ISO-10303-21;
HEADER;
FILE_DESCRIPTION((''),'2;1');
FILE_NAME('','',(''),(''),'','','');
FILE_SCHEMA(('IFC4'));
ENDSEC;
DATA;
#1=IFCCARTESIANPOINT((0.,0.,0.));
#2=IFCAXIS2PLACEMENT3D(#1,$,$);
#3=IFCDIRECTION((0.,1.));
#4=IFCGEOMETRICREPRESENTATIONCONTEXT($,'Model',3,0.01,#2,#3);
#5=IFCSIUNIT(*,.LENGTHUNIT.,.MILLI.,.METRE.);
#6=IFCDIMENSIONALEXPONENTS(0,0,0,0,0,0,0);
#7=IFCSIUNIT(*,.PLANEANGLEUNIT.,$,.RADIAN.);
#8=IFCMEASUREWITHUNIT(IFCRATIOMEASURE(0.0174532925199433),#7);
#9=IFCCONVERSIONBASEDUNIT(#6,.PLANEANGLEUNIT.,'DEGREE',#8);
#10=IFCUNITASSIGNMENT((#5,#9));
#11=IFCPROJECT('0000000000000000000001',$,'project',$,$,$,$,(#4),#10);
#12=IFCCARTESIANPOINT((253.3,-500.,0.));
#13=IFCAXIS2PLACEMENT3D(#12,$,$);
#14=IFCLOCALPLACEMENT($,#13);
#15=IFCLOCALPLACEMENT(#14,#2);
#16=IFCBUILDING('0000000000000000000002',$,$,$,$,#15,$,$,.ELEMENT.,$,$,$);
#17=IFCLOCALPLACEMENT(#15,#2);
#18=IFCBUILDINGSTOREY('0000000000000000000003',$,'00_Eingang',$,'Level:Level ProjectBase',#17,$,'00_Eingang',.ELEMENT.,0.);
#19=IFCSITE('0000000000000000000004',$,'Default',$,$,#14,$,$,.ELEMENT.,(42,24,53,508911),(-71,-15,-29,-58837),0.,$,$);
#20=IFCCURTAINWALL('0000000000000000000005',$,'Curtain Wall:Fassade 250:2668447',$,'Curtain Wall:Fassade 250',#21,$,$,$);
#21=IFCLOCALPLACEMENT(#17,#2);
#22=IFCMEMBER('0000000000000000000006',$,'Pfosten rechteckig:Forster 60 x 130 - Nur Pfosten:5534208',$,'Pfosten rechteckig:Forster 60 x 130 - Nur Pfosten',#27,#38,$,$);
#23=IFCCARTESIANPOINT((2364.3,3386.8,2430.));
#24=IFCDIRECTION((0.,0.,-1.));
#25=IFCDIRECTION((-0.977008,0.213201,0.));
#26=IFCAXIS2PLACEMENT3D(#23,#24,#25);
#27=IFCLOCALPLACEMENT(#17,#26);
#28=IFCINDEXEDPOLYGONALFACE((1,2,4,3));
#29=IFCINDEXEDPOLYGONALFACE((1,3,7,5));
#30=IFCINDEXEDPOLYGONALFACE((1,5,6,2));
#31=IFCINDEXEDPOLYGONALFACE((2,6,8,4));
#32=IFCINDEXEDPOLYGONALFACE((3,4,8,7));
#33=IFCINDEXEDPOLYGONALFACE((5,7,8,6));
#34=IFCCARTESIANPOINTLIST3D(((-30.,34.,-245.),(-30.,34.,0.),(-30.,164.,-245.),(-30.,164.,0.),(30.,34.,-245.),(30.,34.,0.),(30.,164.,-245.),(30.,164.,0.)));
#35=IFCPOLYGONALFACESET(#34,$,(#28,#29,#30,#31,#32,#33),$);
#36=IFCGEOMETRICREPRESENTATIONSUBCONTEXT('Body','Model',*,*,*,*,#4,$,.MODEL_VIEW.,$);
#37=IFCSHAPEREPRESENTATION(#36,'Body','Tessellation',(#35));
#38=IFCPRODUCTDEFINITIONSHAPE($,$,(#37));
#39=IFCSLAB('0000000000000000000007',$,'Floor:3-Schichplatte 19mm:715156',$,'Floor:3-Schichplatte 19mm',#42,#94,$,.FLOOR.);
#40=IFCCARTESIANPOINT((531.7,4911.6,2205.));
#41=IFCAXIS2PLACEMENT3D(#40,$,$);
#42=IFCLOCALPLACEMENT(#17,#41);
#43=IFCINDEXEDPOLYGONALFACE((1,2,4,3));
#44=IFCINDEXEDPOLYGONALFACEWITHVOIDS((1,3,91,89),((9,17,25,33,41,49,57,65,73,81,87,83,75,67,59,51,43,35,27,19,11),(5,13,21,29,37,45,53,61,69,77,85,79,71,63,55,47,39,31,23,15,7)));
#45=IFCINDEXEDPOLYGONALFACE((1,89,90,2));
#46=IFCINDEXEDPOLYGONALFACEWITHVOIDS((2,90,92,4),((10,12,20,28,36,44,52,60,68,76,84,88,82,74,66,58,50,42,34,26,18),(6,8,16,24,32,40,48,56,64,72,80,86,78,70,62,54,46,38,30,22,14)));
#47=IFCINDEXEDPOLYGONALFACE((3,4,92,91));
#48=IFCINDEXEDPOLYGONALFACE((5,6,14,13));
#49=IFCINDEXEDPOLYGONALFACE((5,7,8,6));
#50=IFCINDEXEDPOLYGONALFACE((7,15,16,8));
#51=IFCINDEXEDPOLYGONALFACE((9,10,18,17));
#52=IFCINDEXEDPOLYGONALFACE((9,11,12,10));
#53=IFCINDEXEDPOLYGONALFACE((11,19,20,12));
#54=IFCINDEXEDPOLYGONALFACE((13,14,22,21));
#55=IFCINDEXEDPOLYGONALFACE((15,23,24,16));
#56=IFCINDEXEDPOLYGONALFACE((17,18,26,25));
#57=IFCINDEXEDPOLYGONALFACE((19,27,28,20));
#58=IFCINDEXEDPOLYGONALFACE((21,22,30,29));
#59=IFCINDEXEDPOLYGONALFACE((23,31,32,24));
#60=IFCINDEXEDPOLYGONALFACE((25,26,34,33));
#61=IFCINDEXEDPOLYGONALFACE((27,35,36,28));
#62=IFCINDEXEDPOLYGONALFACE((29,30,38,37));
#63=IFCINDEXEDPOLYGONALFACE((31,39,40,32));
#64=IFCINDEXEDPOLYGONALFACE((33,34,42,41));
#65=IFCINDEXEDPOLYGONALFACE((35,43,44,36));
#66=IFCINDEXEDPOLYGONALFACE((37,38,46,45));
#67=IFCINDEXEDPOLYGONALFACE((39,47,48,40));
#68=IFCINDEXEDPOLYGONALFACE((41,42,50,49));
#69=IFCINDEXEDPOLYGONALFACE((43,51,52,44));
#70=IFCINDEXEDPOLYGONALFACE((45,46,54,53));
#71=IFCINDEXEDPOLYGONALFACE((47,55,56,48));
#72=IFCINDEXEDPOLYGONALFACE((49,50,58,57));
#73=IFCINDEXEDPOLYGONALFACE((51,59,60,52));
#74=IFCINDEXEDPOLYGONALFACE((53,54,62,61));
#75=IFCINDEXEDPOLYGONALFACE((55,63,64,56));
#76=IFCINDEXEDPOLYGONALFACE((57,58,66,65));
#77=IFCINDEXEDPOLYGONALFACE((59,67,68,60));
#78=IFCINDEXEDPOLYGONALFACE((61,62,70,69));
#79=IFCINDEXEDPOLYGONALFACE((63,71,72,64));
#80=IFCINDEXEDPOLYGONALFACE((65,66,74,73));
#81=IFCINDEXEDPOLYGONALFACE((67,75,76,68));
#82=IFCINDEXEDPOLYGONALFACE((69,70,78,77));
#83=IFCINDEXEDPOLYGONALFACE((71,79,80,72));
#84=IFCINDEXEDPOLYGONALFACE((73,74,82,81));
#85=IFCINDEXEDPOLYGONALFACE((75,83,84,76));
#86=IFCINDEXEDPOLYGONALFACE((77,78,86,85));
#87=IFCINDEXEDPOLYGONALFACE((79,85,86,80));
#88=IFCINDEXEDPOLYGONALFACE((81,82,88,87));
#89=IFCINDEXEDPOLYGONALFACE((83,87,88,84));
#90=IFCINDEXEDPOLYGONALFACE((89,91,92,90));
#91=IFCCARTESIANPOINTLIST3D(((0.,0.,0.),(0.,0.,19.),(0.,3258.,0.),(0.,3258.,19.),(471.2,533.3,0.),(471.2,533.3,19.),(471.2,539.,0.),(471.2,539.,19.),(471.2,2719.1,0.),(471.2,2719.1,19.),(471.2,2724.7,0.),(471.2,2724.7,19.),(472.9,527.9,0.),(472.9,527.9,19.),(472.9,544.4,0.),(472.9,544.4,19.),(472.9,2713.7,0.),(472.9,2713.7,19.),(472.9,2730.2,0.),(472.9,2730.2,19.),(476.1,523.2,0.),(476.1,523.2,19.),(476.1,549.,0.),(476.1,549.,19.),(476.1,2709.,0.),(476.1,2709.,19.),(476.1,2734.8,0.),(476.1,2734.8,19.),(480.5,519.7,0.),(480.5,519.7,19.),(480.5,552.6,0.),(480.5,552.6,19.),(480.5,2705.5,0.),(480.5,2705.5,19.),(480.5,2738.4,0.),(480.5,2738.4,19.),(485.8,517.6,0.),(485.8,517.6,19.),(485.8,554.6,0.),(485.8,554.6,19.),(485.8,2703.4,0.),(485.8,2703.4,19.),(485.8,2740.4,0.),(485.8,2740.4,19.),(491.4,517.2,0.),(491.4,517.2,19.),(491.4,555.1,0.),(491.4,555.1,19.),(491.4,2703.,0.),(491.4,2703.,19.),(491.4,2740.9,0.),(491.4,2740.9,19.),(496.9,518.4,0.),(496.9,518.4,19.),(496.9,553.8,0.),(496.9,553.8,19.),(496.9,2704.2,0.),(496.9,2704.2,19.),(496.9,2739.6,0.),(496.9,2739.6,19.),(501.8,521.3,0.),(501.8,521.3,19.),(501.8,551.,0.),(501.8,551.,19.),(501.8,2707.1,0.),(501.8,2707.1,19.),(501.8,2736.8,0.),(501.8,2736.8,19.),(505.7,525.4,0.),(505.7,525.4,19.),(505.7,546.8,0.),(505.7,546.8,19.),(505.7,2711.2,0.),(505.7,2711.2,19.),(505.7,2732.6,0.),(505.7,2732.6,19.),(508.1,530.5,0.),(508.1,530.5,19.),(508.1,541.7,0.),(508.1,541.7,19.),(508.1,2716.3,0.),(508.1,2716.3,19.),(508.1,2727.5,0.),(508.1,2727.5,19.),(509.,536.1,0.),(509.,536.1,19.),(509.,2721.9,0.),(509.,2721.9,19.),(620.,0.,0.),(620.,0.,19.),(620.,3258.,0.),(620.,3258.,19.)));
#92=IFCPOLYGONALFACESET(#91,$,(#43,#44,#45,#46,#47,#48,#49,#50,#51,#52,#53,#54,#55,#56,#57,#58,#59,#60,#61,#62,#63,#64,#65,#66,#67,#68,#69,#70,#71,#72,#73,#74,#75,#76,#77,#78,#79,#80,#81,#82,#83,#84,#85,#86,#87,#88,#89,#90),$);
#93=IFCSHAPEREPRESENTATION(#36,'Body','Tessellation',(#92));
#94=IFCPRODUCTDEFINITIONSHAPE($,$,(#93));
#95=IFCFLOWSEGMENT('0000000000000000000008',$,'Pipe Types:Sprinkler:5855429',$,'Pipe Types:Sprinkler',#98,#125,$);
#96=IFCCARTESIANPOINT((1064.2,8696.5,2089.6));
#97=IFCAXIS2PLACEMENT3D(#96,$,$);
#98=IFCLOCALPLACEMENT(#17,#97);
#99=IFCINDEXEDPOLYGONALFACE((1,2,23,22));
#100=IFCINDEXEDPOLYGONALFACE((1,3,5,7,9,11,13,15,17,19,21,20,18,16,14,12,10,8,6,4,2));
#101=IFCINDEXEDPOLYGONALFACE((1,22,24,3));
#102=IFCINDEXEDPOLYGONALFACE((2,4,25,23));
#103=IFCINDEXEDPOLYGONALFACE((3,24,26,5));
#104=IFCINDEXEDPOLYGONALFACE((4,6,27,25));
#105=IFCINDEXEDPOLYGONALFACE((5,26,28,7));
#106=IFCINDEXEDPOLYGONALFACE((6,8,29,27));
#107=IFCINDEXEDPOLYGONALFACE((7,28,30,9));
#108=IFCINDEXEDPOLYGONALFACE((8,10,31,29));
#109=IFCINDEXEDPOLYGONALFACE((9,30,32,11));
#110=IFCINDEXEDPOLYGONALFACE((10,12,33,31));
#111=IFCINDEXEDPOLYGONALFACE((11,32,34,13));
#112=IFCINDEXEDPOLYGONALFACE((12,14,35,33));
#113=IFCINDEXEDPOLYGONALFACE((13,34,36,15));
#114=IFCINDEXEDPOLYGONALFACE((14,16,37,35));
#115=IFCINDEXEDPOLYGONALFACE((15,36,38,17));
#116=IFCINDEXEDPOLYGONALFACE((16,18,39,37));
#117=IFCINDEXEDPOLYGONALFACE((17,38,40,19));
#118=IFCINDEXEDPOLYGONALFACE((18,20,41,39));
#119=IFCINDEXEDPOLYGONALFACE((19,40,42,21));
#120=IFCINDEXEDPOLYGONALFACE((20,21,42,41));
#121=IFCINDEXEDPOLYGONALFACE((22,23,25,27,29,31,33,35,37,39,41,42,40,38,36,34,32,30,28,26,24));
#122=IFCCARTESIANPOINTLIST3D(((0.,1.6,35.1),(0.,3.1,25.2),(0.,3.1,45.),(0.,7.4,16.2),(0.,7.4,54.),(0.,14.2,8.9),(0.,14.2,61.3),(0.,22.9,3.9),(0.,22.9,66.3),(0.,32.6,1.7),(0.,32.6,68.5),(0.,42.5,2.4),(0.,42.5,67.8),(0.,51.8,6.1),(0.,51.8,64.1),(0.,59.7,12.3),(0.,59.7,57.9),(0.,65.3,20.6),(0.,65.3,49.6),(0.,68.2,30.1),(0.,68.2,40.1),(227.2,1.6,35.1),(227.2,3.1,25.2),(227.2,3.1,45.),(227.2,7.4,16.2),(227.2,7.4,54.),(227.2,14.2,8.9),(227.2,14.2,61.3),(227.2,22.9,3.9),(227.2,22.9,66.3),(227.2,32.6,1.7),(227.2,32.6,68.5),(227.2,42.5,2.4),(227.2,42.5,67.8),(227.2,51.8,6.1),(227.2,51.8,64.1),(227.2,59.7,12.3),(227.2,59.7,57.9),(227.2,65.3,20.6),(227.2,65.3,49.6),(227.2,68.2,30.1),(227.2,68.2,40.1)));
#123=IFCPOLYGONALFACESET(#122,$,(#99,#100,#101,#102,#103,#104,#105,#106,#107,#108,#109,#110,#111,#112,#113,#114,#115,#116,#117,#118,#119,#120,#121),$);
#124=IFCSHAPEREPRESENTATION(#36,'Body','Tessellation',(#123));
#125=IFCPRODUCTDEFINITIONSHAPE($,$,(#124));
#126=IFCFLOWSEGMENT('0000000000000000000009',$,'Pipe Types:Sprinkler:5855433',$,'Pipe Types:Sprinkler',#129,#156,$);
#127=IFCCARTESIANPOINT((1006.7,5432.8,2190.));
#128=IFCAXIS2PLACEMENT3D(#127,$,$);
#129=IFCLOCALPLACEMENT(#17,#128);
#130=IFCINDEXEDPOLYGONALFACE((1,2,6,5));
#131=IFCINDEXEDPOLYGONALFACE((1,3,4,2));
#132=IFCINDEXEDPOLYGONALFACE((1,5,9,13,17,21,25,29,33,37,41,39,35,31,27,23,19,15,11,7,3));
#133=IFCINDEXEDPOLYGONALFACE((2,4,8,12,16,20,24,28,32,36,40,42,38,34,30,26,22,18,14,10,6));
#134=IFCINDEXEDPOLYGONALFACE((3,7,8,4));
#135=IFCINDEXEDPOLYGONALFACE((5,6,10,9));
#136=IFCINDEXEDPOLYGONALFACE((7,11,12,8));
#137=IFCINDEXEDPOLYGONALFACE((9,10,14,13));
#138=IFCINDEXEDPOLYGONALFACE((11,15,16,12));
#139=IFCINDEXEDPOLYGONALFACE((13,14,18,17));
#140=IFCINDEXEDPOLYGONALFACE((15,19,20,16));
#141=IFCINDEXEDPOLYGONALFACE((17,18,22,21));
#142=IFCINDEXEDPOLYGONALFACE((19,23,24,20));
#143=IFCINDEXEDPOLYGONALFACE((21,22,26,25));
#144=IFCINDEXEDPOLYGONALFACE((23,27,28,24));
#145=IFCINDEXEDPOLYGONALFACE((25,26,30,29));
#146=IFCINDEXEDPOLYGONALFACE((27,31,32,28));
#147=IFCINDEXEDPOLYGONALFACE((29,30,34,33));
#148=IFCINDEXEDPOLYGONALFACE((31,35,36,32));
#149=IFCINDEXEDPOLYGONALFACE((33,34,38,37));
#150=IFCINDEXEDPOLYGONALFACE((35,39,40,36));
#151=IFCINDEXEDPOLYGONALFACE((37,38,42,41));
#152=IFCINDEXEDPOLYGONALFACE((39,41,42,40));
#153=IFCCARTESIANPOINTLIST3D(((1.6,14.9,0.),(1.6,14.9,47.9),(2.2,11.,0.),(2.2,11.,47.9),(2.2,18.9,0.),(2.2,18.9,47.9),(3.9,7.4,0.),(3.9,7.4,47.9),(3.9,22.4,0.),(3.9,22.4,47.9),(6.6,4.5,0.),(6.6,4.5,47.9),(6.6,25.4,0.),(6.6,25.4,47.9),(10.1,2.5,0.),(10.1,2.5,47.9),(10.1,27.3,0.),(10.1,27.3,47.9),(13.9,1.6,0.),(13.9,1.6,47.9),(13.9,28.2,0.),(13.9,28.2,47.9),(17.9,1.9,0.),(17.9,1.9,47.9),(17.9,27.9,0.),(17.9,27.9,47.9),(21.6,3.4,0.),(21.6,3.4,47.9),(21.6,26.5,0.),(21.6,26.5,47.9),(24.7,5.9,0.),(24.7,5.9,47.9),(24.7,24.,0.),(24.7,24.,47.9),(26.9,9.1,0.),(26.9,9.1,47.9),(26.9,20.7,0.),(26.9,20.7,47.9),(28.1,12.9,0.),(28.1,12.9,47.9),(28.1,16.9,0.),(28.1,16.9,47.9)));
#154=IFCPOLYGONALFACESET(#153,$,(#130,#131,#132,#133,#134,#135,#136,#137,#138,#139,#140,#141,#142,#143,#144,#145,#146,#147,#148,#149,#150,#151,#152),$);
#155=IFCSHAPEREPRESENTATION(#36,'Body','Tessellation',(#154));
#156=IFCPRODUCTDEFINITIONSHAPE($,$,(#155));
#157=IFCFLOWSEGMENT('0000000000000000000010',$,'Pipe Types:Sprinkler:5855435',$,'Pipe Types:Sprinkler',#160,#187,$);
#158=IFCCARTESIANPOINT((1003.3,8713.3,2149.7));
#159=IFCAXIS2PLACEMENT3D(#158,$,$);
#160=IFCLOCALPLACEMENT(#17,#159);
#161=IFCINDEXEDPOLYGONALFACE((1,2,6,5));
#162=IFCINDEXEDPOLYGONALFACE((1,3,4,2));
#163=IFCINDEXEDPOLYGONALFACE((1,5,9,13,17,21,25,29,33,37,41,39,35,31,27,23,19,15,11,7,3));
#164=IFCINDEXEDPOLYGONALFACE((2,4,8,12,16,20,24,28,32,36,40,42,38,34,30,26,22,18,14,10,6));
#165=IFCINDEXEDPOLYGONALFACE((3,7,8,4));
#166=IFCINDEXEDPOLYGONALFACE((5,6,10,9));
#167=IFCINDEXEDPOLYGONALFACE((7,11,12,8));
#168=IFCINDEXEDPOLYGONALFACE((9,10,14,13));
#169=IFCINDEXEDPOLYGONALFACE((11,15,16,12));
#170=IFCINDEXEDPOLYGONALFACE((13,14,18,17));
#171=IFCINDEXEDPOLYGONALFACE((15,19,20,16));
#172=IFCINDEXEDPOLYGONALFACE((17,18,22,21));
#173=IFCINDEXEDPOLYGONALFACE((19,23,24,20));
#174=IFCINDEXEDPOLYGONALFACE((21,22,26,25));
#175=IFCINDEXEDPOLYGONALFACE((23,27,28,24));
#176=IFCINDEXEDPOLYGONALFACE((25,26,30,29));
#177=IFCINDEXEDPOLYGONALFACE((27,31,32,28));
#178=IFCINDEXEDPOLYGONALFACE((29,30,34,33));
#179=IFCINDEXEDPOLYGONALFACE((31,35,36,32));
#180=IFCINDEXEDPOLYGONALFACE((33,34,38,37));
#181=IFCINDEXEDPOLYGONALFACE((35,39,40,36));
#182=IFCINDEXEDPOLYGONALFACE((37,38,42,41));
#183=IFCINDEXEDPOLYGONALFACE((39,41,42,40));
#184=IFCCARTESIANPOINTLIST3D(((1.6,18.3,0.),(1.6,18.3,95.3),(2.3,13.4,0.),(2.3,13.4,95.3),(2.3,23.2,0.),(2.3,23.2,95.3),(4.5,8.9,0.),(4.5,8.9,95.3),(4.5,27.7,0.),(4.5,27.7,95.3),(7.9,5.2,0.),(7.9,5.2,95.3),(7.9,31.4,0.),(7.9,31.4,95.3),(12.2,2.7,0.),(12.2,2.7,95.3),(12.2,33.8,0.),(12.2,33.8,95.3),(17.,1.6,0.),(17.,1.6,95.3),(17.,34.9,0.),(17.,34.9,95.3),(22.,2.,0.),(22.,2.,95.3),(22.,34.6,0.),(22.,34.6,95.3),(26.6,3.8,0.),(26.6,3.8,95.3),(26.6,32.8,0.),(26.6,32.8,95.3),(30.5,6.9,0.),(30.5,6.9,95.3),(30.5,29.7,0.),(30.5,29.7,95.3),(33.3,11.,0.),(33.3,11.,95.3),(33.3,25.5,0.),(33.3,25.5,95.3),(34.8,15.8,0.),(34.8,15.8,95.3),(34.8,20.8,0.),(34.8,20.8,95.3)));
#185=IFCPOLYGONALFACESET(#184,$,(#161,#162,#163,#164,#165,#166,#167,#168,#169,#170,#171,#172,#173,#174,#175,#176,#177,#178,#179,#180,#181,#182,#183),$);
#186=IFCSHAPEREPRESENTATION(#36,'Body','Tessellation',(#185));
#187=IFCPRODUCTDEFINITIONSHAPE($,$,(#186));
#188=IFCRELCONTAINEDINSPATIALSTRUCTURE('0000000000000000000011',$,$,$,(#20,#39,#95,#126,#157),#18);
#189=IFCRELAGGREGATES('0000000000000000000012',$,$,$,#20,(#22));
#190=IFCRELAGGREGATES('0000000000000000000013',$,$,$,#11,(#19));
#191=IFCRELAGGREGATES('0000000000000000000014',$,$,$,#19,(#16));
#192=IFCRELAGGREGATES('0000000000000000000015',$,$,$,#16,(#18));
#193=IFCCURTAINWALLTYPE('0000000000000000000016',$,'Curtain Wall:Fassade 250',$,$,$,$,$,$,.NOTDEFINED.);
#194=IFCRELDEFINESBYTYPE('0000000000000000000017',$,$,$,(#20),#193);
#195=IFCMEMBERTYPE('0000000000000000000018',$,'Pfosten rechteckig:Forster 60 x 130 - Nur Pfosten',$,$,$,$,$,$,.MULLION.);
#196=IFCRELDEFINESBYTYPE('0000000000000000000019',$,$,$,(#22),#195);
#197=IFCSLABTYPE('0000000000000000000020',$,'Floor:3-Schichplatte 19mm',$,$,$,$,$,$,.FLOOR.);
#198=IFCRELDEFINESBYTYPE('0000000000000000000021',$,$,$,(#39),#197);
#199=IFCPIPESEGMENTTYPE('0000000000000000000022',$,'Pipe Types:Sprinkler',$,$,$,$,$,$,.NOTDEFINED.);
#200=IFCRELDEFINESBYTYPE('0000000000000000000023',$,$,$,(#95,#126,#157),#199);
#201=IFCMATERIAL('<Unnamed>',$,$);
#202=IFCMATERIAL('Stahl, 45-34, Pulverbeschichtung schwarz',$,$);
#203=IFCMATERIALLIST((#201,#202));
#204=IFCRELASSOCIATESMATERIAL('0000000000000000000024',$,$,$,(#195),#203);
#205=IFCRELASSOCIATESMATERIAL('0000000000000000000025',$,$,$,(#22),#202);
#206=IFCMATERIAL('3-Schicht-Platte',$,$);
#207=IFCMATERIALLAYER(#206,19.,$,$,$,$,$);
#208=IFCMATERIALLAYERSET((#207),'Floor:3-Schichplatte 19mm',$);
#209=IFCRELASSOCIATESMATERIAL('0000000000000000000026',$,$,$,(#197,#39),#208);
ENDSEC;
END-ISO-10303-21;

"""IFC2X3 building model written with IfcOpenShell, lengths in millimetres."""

from ifc_helpers import new_model, entity, si_unit, converted_unit, direction, frame, frame_2d, origin, origin_2d_with_axis, place, context, subcontext, project, spatial, rectangle, circle, extrude, source, transform, mapped, material, material_list, layer, layer_set, layer_usage, type_object, type_shapes, element, aggregate, save


model = new_model("IFC2X3")

# Units and contexts
model_context = context("Model", 3, precision=0.01, world=origin(), true_north=direction((0.0, 1.0)))
body_context = subcontext(model_context, "Body", "Model", "MODEL_VIEW")
ifc_project = project(units=[si_unit("LENGTHUNIT", "METRE", prefix="MILLI"), converted_unit("PLANEANGLEUNIT", "DEGREE", entity("IfcRatioMeasure", 0.0174532925199433), si_unit("PLANEANGLEUNIT", "RADIAN"), dimensions=[0, 0, 0, 0, 0, 0, 0])], contexts=[model_context])

# Site, building, storey
site_placement = place(None, frame((253.3, -500.0, 0.0)))
site = spatial("IfcSite", under=ifc_project, at=site_placement, Name="Default", CompositionType="ELEMENT", RefLatitude=(42, 24, 53, 508911), RefLongitude=(-71, -15, -29, -58837), RefElevation=0.0)
building_placement = place(site_placement, origin())
building = spatial("IfcBuilding", under=site, at=building_placement, CompositionType="ELEMENT")
storey_placement = place(building_placement, origin())
storey = spatial("IfcBuildingStorey", under=building, at=storey_placement, Name="00_Eingang", ObjectType="Level:Level ProjectBase", LongName="00_Eingang", CompositionType="ELEMENT", Elevation=0.0)

# Curtain wall, member
curtain_wall_type = type_object("IfcCurtainWallType", Name="Curtain Wall:Fassade 250", PredefinedType="NOTDEFINED")
curtain_wall_placement = place(storey_placement, origin())
curtain_wall = element("IfcCurtainWall", 1, at=curtain_wall_placement, inside=storey, type_object=curtain_wall_type, Name="Curtain Wall:Fassade 250:2668447", ObjectType="Curtain Wall:Fassade 250")
ifc_material_1 = material(Name="Stahl, 45-34, Pulverbeschichtung schwarz")
ifc_material_2 = material(Name="<Unnamed>")
ifc_material_list = material_list([ifc_material_2, ifc_material_1])
member_type = type_object("IfcMemberType", Name="Pfosten rechteckig:Forster 60 x 130 - Nur Pfosten", PredefinedType="MULLION", material=ifc_material_list)
shared_shape_1 = source(origin(), body_context, "Body", "SweptSolid", [
    extrude(rectangle(XDim=130.0, YDim=60.0, at=origin_2d_with_axis()), frame((0.0, 99.0, -245.0), z_axis=(0.0, 0.0, 1.0), x_axis=(0.0, -1.0, 0.0)), (0.0, 0.0, 1.0), 245.0),
])
type_shapes(member_type, [shared_shape_1])
member_placement = place(storey_placement, frame((2364.3, 3386.8, 2430.0), z_axis=(0.0, 0.0, -1.0), x_axis=(-0.977008, 0.213201, 0.0)))
member = element("IfcMember", 2, at=member_placement, type_object=member_type, material=ifc_material_1, Name="Pfosten rechteckig:Forster 60 x 130 - Nur Pfosten:5534208", ObjectType="Pfosten rechteckig:Forster 60 x 130 - Nur Pfosten", context=body_context, shape_type="MappedRepresentation", body=[
    mapped(shared_shape_1, transform((0.0, 0.0, 0.0), scale=1.0)),
])

# Slab, openings
ifc_material_3 = material(Name="3-Schicht-Platte")
ifc_layer_1 = layer(ifc_material_3, 19.0)
ifc_layer_set_1 = layer_set([ifc_layer_1], Name="Floor:3-Schichplatte 19mm")
ifc_layer_usage_1 = layer_usage(ifc_layer_set_1, "AXIS3", "POSITIVE", 0.0)
slab_type = type_object("IfcSlabType", Name="Floor:3-Schichplatte 19mm", PredefinedType="FLOOR", material=ifc_layer_set_1)
slab_placement = place(storey_placement, frame((531.7, 4911.6, 2205.0)))
slab = element("IfcSlab", 3, at=slab_placement, inside=storey, type_object=slab_type, material=ifc_layer_usage_1, Name="Floor:3-Schichplatte 19mm:715156", ObjectType="Floor:3-Schichplatte 19mm", PredefinedType="FLOOR", context=body_context, shape_type="SweptSolid", body=[
    extrude(rectangle(XDim=620.0, YDim=3258.0, at=origin_2d_with_axis()), frame((310.0, 1629.0, 19.0), z_axis=(0.0, 0.0, -1.0), x_axis=(-1.0, 0.0, 0.0)), (0.0, 0.0, 1.0), 19.0),
])
opening_1_placement = place(slab_placement, origin())
element("IfcOpeningElement", 4, at=opening_1_placement, cuts=slab, ObjectType="Opening", context=body_context, shape_type="SweptSolid", body=[
    extrude(circle(Radius=19.0, at=origin_2d_with_axis()), frame((490.0, 2721.9, -205.0)), (0.0, 0.0, 1.0), 500.0),
])
opening_2_placement = place(slab_placement, origin())
element("IfcOpeningElement", 5, at=opening_2_placement, cuts=slab, ObjectType="Opening", context=body_context, shape_type="SweptSolid", body=[
    extrude(circle(Radius=19.0, at=origin_2d_with_axis()), frame((490.0, 536.1, -205.0)), (0.0, 0.0, 1.0), 500.0),
])

aggregate(curtain_wall, [member])

# Flow segments
pipe_segment_type = type_object("IfcPipeSegmentType", Name="Pipe Types:Sprinkler", PredefinedType="NOTDEFINED")
flow_segment_1_placement = place(storey_placement, frame((1064.2, 8696.5, 2089.6)))
element("IfcFlowSegment", 6, at=flow_segment_1_placement, inside=storey, type_object=pipe_segment_type, Name="Pipe Types:Sprinkler:5855429", ObjectType="Pipe Types:Sprinkler", context=body_context, shape_type="SweptSolid", body=[
    extrude(circle(Radius=33.5, at=origin_2d_with_axis()), frame((0.0, 35.1, 35.1), z_axis=(1.0, 0.0, 0.0), x_axis=(0.0, -1.0, 0.0)), (0.0, 0.0, 1.0), 227.2),
])
flow_segment_2_placement = place(storey_placement, frame((1006.7, 5432.8, 2190.0)))
element("IfcFlowSegment", 7, at=flow_segment_2_placement, inside=storey, type_object=pipe_segment_type, Name="Pipe Types:Sprinkler:5855433", ObjectType="Pipe Types:Sprinkler", context=body_context, shape_type="SweptSolid", body=[
    extrude(circle(Radius=13.3, at=frame_2d((0.0, 0.0), x_axis=(1.0, 0.0))), frame((14.9, 14.9, 0.0), z_axis=(0.0, 0.0, 1.0), x_axis=(-1.0, 0.0, 0.0)), (0.0, 0.0, 1.0), 47.9),
])
flow_segment_3_placement = place(storey_placement, frame((1003.3, 8713.3, 2149.7)))
element("IfcFlowSegment", 8, at=flow_segment_3_placement, inside=storey, type_object=pipe_segment_type, Name="Pipe Types:Sprinkler:5855435", ObjectType="Pipe Types:Sprinkler", context=body_context, shape_type="SweptSolid", body=[
    extrude(circle(Radius=16.7, at=frame_2d((0.0, 0.0), x_axis=(1.0, 0.0))), frame((18.3, 18.3, 0.0), z_axis=(0.0, 0.0, 1.0), x_axis=(-1.0, 0.0, 0.0)), (0.0, 0.0, 1.0), 95.3),
])

save(model, "model.ifc")
